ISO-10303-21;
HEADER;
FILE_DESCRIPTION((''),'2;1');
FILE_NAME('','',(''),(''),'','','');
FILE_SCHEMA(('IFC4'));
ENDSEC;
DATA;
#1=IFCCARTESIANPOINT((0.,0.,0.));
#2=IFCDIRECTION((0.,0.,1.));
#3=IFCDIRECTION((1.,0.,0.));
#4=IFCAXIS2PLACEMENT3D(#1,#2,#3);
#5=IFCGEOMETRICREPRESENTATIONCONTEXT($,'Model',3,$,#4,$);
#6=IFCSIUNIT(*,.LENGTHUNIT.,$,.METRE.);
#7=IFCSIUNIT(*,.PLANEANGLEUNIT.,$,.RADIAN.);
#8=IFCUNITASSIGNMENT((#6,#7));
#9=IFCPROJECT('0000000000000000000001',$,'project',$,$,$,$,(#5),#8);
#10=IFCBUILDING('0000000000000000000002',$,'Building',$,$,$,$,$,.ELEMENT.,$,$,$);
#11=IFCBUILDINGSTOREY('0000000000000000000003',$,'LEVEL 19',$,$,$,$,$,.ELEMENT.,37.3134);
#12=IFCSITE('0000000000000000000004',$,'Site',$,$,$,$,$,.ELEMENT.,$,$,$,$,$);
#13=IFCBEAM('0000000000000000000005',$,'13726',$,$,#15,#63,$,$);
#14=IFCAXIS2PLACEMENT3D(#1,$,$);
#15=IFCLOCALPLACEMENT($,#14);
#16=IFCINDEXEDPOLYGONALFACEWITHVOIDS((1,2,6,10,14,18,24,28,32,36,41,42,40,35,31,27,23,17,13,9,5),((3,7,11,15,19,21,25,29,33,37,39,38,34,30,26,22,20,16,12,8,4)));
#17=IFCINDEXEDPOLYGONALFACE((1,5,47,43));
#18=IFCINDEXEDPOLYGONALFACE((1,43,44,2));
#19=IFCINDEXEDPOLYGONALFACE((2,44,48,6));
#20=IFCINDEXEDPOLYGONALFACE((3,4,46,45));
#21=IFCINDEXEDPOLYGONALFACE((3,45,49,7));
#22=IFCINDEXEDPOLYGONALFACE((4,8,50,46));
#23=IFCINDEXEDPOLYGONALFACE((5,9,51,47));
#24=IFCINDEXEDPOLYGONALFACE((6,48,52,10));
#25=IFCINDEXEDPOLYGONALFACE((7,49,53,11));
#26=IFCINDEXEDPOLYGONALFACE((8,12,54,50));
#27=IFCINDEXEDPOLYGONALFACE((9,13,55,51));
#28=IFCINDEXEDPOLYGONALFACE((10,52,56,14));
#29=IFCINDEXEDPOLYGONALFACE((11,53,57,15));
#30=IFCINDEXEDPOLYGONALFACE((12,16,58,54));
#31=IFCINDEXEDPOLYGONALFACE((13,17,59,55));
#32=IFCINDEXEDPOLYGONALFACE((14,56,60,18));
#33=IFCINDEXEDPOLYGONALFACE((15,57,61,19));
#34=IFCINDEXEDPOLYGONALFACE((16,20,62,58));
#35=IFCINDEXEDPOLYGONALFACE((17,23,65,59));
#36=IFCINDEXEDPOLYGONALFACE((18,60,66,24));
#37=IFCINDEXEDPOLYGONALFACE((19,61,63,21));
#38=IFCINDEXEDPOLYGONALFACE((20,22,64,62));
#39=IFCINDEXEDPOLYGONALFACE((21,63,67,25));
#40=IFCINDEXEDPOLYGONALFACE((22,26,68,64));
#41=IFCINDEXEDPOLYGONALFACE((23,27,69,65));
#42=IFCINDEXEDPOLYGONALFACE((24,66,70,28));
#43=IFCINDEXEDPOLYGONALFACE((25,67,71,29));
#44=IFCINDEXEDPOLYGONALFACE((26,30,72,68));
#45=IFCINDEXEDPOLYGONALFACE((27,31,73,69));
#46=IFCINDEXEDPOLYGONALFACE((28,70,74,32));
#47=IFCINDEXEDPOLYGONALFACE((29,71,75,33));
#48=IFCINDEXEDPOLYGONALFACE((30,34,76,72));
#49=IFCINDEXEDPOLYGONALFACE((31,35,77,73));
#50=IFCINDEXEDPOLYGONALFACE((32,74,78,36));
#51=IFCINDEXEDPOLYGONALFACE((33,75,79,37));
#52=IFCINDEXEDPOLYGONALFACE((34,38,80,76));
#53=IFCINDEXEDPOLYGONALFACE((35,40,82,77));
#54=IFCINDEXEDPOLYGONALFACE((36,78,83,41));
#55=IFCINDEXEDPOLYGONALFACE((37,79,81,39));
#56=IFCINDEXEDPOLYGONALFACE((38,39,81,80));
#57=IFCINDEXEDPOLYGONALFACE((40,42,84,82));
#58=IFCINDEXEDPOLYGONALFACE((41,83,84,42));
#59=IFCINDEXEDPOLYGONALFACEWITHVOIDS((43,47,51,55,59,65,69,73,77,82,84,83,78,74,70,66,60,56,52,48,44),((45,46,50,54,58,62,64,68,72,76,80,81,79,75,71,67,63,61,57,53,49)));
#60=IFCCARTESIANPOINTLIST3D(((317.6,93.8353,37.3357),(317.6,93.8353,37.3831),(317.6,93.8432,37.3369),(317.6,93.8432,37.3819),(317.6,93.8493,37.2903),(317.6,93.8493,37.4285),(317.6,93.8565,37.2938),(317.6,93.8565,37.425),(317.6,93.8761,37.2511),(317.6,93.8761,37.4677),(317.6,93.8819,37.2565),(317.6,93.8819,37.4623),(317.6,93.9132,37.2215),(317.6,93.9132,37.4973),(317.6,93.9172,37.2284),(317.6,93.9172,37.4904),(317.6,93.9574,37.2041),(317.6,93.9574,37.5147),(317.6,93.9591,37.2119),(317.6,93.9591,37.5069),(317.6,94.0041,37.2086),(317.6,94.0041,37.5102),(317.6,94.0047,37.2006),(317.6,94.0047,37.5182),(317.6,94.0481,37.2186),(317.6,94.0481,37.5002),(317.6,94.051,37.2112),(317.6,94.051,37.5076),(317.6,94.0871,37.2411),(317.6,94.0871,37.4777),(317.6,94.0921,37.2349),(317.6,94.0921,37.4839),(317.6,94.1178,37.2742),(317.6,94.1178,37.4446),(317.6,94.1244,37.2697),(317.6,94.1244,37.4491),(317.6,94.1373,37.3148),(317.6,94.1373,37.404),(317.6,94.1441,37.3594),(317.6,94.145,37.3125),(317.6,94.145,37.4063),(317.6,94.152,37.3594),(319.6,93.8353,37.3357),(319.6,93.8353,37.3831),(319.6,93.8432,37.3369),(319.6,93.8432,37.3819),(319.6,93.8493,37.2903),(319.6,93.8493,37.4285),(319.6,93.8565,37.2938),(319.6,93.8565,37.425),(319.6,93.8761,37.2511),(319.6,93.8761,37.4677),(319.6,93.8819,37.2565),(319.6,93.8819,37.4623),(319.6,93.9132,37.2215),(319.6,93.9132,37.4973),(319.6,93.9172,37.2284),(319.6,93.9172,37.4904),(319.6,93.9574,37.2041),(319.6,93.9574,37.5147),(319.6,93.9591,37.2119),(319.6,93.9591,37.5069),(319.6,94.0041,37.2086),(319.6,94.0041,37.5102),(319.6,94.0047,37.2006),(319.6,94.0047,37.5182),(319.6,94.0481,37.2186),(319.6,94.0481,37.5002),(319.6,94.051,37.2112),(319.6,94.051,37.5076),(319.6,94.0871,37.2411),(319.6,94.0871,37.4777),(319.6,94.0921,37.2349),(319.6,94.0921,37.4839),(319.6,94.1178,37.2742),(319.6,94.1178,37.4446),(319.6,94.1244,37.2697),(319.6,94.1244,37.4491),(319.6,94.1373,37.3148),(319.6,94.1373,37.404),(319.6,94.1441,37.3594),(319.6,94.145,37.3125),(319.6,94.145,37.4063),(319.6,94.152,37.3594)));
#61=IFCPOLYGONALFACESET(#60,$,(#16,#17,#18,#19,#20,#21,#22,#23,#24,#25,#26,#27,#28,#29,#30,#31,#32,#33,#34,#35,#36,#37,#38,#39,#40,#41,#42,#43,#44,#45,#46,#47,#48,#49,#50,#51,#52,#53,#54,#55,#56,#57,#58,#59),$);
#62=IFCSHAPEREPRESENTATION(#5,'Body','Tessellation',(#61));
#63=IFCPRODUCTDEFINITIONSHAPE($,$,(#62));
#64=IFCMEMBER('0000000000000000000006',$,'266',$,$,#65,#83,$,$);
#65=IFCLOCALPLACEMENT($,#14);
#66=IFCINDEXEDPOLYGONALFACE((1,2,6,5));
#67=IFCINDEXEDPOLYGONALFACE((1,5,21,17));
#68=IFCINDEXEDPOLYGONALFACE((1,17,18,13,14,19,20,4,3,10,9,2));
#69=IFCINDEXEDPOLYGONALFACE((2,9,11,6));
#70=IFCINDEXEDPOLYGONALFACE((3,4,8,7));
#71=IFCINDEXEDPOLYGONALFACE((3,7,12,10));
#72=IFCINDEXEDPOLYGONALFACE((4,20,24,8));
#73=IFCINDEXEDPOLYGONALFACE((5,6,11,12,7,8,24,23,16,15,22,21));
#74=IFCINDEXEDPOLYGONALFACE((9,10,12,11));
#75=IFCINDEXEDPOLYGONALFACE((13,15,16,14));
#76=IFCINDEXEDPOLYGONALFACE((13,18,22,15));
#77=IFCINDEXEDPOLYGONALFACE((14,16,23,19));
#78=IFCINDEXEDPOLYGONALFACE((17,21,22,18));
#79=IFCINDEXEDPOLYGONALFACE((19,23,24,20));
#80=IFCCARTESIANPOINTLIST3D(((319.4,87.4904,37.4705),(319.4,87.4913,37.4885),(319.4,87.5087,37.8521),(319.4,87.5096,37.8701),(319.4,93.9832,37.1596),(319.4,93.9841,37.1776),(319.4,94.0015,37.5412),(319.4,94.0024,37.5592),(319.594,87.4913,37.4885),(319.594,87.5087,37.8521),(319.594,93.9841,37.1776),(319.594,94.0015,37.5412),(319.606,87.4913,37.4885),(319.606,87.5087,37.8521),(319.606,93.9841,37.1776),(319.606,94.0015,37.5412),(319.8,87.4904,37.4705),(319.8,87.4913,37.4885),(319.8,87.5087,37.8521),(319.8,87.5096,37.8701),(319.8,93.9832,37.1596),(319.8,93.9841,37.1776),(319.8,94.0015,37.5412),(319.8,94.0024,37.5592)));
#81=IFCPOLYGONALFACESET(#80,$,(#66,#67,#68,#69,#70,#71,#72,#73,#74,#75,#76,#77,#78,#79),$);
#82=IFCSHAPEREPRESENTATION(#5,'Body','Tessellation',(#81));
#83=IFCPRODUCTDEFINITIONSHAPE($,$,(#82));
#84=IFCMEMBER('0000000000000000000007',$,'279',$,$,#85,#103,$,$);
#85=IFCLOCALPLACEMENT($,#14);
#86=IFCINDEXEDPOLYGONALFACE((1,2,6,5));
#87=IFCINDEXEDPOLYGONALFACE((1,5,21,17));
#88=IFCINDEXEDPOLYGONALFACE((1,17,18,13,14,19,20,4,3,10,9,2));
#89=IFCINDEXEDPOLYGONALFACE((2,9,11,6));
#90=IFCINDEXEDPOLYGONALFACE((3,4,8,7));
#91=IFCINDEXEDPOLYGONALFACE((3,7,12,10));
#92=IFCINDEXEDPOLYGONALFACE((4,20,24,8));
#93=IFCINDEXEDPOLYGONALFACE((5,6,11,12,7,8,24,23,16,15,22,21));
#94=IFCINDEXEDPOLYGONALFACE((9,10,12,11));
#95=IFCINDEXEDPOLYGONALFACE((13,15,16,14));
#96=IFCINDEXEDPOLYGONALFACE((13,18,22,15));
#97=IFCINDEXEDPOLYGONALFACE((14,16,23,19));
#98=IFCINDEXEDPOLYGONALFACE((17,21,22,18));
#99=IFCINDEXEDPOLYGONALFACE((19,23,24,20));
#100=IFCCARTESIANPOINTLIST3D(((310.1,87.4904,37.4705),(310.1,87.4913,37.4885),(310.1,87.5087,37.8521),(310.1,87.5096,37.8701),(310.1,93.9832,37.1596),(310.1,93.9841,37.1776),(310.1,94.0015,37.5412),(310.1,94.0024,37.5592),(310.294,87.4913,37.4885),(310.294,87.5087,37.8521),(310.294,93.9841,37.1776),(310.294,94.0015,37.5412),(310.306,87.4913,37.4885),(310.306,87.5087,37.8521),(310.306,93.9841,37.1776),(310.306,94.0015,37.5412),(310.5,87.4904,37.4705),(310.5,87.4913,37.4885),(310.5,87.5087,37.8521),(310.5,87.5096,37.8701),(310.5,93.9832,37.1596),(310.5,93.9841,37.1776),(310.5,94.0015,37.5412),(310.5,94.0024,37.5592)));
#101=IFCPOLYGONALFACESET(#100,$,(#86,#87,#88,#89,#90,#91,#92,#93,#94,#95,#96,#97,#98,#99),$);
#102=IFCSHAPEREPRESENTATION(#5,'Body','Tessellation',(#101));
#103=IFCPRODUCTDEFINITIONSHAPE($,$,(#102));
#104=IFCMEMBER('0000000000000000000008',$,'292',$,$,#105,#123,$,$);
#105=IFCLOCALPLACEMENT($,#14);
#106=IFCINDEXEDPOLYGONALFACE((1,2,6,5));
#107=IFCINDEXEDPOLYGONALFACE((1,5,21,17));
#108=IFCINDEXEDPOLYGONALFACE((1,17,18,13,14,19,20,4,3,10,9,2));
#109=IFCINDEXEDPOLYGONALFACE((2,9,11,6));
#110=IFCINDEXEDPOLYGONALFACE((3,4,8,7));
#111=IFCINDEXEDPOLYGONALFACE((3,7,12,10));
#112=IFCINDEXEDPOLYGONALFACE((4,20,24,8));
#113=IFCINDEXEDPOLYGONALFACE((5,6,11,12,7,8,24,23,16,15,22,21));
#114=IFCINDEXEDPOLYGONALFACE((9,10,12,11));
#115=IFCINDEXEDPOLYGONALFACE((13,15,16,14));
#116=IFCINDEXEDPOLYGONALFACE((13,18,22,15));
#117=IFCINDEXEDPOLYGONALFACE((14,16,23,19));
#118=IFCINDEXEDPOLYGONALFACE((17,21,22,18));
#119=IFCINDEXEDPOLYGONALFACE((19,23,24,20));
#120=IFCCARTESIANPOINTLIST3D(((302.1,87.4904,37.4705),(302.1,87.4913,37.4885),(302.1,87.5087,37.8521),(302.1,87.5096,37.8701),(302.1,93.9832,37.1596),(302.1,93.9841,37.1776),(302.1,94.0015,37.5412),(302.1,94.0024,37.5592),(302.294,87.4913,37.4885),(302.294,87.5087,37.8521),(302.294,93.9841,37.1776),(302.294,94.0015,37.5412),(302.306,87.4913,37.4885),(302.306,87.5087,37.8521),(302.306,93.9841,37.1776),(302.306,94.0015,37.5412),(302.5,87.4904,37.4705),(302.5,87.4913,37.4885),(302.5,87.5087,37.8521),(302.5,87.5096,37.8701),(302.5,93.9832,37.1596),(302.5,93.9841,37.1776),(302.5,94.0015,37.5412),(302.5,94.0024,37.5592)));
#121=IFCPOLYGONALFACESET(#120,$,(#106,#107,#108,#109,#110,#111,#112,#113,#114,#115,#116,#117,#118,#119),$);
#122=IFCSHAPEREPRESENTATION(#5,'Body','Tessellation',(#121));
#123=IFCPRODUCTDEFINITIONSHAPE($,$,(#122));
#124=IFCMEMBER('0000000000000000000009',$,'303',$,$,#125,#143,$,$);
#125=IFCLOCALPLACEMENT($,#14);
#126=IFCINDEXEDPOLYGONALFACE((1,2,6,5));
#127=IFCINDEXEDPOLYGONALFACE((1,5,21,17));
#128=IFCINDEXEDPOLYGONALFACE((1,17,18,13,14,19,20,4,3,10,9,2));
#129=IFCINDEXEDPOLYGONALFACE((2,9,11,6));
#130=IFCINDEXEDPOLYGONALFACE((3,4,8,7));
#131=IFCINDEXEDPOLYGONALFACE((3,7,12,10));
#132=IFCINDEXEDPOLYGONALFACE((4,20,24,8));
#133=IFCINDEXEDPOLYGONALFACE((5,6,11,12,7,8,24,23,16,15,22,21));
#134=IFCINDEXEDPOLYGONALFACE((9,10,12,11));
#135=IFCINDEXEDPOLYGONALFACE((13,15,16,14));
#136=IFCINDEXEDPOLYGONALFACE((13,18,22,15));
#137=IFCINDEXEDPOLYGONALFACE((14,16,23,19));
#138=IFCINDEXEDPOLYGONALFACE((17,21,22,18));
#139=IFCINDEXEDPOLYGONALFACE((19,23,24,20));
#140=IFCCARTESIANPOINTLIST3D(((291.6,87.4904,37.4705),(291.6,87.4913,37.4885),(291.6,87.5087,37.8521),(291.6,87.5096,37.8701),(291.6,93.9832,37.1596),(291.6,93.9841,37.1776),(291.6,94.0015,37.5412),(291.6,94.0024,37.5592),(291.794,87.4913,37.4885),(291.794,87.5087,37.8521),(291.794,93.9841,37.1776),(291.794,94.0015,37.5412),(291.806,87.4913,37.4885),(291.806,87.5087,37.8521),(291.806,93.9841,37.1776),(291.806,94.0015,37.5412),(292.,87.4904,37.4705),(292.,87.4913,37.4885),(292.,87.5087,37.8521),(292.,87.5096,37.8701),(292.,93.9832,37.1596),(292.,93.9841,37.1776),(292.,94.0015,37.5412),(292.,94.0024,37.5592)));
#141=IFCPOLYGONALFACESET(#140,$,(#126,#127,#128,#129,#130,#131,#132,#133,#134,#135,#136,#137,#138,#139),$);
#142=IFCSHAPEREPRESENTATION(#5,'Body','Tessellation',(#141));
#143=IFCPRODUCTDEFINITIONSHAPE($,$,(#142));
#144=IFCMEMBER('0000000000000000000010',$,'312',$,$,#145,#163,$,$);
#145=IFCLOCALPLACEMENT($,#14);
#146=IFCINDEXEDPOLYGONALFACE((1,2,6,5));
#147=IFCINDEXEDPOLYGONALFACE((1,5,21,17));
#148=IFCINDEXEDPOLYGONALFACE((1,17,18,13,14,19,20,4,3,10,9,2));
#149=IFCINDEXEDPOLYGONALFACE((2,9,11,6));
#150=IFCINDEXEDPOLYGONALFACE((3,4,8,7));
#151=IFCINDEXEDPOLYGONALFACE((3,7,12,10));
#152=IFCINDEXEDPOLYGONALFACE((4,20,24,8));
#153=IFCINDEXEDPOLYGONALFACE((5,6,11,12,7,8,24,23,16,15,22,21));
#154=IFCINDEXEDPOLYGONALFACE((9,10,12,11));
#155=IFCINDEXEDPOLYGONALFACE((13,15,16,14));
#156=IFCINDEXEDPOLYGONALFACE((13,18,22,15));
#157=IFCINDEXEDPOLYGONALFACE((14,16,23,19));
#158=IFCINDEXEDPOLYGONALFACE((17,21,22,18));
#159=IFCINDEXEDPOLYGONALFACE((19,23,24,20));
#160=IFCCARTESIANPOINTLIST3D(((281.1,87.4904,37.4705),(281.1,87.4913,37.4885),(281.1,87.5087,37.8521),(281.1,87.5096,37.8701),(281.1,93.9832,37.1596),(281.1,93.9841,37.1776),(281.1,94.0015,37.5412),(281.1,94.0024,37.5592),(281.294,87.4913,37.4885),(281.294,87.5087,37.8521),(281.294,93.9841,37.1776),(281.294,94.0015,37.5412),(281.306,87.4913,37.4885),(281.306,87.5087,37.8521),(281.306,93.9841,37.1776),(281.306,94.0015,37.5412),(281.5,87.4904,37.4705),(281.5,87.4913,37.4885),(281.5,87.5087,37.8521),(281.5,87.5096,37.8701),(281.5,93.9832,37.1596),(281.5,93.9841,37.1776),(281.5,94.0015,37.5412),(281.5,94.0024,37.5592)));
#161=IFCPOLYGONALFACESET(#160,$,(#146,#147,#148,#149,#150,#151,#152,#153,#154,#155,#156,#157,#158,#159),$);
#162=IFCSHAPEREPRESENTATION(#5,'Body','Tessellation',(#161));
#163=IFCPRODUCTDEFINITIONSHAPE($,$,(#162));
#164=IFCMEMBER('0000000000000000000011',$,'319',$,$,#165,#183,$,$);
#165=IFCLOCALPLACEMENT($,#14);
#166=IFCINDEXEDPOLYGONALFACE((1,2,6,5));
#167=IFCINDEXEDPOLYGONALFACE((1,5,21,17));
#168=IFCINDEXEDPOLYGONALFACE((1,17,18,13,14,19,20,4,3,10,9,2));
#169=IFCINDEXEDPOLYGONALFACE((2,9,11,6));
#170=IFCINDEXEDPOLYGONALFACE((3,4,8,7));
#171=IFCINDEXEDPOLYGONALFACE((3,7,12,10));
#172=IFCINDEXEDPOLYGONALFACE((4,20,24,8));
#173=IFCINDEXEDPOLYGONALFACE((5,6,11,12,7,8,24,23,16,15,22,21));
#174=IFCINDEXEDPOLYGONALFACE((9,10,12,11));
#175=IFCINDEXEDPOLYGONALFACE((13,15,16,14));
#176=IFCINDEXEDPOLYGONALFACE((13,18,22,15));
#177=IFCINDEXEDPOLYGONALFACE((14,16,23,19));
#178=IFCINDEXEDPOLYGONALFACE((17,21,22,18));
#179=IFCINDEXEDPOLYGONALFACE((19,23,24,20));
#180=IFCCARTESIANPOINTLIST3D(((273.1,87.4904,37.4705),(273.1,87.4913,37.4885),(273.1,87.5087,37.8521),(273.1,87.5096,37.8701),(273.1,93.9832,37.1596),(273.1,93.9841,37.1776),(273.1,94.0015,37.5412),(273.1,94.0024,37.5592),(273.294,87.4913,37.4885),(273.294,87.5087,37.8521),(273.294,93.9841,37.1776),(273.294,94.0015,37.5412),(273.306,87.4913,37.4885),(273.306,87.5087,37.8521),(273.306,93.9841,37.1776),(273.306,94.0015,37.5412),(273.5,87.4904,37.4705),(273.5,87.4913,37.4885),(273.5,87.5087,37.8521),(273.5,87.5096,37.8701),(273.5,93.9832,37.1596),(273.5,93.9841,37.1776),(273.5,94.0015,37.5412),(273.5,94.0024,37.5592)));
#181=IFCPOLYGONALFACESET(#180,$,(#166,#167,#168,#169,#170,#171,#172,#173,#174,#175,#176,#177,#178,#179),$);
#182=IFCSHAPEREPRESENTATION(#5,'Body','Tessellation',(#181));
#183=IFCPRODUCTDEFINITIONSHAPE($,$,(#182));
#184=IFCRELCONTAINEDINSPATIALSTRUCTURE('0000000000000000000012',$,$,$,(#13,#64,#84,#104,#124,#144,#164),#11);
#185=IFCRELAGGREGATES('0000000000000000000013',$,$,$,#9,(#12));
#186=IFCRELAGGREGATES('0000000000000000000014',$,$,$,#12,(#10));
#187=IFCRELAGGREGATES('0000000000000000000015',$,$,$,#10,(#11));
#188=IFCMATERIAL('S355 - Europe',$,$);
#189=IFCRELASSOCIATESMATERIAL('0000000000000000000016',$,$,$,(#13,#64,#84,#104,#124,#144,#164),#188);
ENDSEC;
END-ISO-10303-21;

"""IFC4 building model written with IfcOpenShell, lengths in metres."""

from ifc_helpers import new_model, si_unit, frame, origin_with_axes, origin_2d_with_axis, place, context, project, spatial, hollow_circle, i_section, extrude, material, material_profile, profile_set, profile_usage, element, save


model = new_model("IFC4")

# Units and contexts
model_context = context("Model", 3, world=origin_with_axes())
ifc_project = project(units=[si_unit("LENGTHUNIT", "METRE"), si_unit("PLANEANGLEUNIT", "RADIAN")], contexts=[model_context])

# Site, building, storey
site = spatial("IfcSite", under=ifc_project, Name="Site", CompositionType="ELEMENT")
building = spatial("IfcBuilding", under=site, Name="Building", CompositionType="ELEMENT")
storey = spatial("IfcBuildingStorey", under=building, Name="LEVEL 19", CompositionType="ELEMENT", Elevation=37.3134)

# Beam
ifc_material = material(Name="S355 - Europe")
ifc_material_profile_1 = material_profile(ifc_material, hollow_circle(Radius=0.1593, WallThickness=0.008, at=origin_2d_with_axis()))
ifc_profile_set_1 = profile_set([ifc_material_profile_1])
ifc_profile_usage_1 = profile_usage(ifc_profile_set_1, cardinal=10)
beam_1_placement = place(None, frame((317.6, 93.9928, 37.3594), z_axis=(1.0, 0.0, 0.0), x_axis=(0.0, 1.0, 0.0)))
element("IfcBeam", 1, at=beam_1_placement, inside=storey, material=ifc_profile_usage_1, Name="13726", context=model_context, shape_type="SweptSolid", body=[
    extrude(hollow_circle(Radius=0.1593, WallThickness=0.008, at=origin_2d_with_axis()), origin_with_axes(), (0.0, 0.0, 1.0), 2.0),
])

# Members
ifc_material_profile_2 = material_profile(ifc_material, i_section(OverallWidth=0.4, OverallDepth=0.4, WebThickness=0.012, FlangeThickness=0.018, at=origin_2d_with_axis()))
ifc_profile_set_2 = profile_set([ifc_material_profile_2])
ifc_profile_usage_2 = profile_usage(ifc_profile_set_2, cardinal=10)
member_1_placement = place(None, frame((319.6, 93.9928, 37.3594), z_axis=(0.0, -0.998856, 0.047828), x_axis=(1.0, 0.0, 0.0)))
element("IfcMember", 2, at=member_1_placement, inside=storey, material=ifc_profile_usage_2, Name="266", context=model_context, shape_type="SweptSolid", body=[
    extrude(i_section(OverallWidth=0.4, OverallDepth=0.4, WebThickness=0.012, FlangeThickness=0.018, at=origin_2d_with_axis()), origin_with_axes(), (0.0, 0.0, 1.0), 6.5002),
])
ifc_material_profile_3 = material_profile(ifc_material, i_section(OverallWidth=0.4, OverallDepth=0.4, WebThickness=0.012, FlangeThickness=0.018, at=origin_2d_with_axis()))
ifc_profile_set_3 = profile_set([ifc_material_profile_3])
ifc_profile_usage_3 = profile_usage(ifc_profile_set_3, cardinal=10)
member_2_placement = place(None, frame((310.3, 93.9928, 37.3594), z_axis=(0.0, -0.998856, 0.047828), x_axis=(1.0, 0.0, 0.0)))
element("IfcMember", 3, at=member_2_placement, inside=storey, material=ifc_profile_usage_3, Name="279", context=model_context, shape_type="SweptSolid", body=[
    extrude(i_section(OverallWidth=0.4, OverallDepth=0.4, WebThickness=0.012, FlangeThickness=0.018, at=origin_2d_with_axis()), origin_with_axes(), (0.0, 0.0, 1.0), 6.5002),
])
ifc_material_profile_4 = material_profile(ifc_material, i_section(OverallWidth=0.4, OverallDepth=0.4, WebThickness=0.012, FlangeThickness=0.018, at=origin_2d_with_axis()))
ifc_profile_set_4 = profile_set([ifc_material_profile_4])
ifc_profile_usage_4 = profile_usage(ifc_profile_set_4, cardinal=10)
member_3_placement = place(None, frame((302.3, 93.9928, 37.3594), z_axis=(0.0, -0.998856, 0.047828), x_axis=(1.0, 0.0, 0.0)))
element("IfcMember", 4, at=member_3_placement, inside=storey, material=ifc_profile_usage_4, Name="292", context=model_context, shape_type="SweptSolid", body=[
    extrude(i_section(OverallWidth=0.4, OverallDepth=0.4, WebThickness=0.012, FlangeThickness=0.018, at=origin_2d_with_axis()), origin_with_axes(), (0.0, 0.0, 1.0), 6.5002),
])
ifc_material_profile_5 = material_profile(ifc_material, i_section(OverallWidth=0.4, OverallDepth=0.4, WebThickness=0.012, FlangeThickness=0.018, at=origin_2d_with_axis()))
ifc_profile_set_5 = profile_set([ifc_material_profile_5])
ifc_profile_usage_5 = profile_usage(ifc_profile_set_5, cardinal=10)
member_4_placement = place(None, frame((291.8, 93.9928, 37.3594), z_axis=(0.0, -0.998856, 0.047828), x_axis=(1.0, 0.0, 0.0)))
element("IfcMember", 5, at=member_4_placement, inside=storey, material=ifc_profile_usage_5, Name="303", context=model_context, shape_type="SweptSolid", body=[
    extrude(i_section(OverallWidth=0.4, OverallDepth=0.4, WebThickness=0.012, FlangeThickness=0.018, at=origin_2d_with_axis()), origin_with_axes(), (0.0, 0.0, 1.0), 6.5002),
])
ifc_material_profile_6 = material_profile(ifc_material, i_section(OverallWidth=0.4, OverallDepth=0.4, WebThickness=0.012, FlangeThickness=0.018, at=origin_2d_with_axis()))
ifc_profile_set_6 = profile_set([ifc_material_profile_6])
ifc_profile_usage_6 = profile_usage(ifc_profile_set_6, cardinal=10)
member_5_placement = place(None, frame((281.3, 93.9928, 37.3594), z_axis=(0.0, -0.998856, 0.047828), x_axis=(1.0, 0.0, 0.0)))
element("IfcMember", 6, at=member_5_placement, inside=storey, material=ifc_profile_usage_6, Name="312", context=model_context, shape_type="SweptSolid", body=[
    extrude(i_section(OverallWidth=0.4, OverallDepth=0.4, WebThickness=0.012, FlangeThickness=0.018, at=origin_2d_with_axis()), origin_with_axes(), (0.0, 0.0, 1.0), 6.5002),
])
ifc_material_profile_7 = material_profile(ifc_material, i_section(OverallWidth=0.4, OverallDepth=0.4, WebThickness=0.012, FlangeThickness=0.018, at=origin_2d_with_axis()))
ifc_profile_set_7 = profile_set([ifc_material_profile_7])
ifc_profile_usage_7 = profile_usage(ifc_profile_set_7, cardinal=10)
member_6_placement = place(None, frame((273.3, 93.9928, 37.3594), z_axis=(0.0, -0.998856, 0.047828), x_axis=(1.0, 0.0, 0.0)))
element("IfcMember", 7, at=member_6_placement, inside=storey, material=ifc_profile_usage_7, Name="319", context=model_context, shape_type="SweptSolid", body=[
    extrude(i_section(OverallWidth=0.4, OverallDepth=0.4, WebThickness=0.012, FlangeThickness=0.018, at=origin_2d_with_axis()), origin_with_axes(), (0.0, 0.0, 1.0), 6.5002),
])

save(model, "model.ifc")
